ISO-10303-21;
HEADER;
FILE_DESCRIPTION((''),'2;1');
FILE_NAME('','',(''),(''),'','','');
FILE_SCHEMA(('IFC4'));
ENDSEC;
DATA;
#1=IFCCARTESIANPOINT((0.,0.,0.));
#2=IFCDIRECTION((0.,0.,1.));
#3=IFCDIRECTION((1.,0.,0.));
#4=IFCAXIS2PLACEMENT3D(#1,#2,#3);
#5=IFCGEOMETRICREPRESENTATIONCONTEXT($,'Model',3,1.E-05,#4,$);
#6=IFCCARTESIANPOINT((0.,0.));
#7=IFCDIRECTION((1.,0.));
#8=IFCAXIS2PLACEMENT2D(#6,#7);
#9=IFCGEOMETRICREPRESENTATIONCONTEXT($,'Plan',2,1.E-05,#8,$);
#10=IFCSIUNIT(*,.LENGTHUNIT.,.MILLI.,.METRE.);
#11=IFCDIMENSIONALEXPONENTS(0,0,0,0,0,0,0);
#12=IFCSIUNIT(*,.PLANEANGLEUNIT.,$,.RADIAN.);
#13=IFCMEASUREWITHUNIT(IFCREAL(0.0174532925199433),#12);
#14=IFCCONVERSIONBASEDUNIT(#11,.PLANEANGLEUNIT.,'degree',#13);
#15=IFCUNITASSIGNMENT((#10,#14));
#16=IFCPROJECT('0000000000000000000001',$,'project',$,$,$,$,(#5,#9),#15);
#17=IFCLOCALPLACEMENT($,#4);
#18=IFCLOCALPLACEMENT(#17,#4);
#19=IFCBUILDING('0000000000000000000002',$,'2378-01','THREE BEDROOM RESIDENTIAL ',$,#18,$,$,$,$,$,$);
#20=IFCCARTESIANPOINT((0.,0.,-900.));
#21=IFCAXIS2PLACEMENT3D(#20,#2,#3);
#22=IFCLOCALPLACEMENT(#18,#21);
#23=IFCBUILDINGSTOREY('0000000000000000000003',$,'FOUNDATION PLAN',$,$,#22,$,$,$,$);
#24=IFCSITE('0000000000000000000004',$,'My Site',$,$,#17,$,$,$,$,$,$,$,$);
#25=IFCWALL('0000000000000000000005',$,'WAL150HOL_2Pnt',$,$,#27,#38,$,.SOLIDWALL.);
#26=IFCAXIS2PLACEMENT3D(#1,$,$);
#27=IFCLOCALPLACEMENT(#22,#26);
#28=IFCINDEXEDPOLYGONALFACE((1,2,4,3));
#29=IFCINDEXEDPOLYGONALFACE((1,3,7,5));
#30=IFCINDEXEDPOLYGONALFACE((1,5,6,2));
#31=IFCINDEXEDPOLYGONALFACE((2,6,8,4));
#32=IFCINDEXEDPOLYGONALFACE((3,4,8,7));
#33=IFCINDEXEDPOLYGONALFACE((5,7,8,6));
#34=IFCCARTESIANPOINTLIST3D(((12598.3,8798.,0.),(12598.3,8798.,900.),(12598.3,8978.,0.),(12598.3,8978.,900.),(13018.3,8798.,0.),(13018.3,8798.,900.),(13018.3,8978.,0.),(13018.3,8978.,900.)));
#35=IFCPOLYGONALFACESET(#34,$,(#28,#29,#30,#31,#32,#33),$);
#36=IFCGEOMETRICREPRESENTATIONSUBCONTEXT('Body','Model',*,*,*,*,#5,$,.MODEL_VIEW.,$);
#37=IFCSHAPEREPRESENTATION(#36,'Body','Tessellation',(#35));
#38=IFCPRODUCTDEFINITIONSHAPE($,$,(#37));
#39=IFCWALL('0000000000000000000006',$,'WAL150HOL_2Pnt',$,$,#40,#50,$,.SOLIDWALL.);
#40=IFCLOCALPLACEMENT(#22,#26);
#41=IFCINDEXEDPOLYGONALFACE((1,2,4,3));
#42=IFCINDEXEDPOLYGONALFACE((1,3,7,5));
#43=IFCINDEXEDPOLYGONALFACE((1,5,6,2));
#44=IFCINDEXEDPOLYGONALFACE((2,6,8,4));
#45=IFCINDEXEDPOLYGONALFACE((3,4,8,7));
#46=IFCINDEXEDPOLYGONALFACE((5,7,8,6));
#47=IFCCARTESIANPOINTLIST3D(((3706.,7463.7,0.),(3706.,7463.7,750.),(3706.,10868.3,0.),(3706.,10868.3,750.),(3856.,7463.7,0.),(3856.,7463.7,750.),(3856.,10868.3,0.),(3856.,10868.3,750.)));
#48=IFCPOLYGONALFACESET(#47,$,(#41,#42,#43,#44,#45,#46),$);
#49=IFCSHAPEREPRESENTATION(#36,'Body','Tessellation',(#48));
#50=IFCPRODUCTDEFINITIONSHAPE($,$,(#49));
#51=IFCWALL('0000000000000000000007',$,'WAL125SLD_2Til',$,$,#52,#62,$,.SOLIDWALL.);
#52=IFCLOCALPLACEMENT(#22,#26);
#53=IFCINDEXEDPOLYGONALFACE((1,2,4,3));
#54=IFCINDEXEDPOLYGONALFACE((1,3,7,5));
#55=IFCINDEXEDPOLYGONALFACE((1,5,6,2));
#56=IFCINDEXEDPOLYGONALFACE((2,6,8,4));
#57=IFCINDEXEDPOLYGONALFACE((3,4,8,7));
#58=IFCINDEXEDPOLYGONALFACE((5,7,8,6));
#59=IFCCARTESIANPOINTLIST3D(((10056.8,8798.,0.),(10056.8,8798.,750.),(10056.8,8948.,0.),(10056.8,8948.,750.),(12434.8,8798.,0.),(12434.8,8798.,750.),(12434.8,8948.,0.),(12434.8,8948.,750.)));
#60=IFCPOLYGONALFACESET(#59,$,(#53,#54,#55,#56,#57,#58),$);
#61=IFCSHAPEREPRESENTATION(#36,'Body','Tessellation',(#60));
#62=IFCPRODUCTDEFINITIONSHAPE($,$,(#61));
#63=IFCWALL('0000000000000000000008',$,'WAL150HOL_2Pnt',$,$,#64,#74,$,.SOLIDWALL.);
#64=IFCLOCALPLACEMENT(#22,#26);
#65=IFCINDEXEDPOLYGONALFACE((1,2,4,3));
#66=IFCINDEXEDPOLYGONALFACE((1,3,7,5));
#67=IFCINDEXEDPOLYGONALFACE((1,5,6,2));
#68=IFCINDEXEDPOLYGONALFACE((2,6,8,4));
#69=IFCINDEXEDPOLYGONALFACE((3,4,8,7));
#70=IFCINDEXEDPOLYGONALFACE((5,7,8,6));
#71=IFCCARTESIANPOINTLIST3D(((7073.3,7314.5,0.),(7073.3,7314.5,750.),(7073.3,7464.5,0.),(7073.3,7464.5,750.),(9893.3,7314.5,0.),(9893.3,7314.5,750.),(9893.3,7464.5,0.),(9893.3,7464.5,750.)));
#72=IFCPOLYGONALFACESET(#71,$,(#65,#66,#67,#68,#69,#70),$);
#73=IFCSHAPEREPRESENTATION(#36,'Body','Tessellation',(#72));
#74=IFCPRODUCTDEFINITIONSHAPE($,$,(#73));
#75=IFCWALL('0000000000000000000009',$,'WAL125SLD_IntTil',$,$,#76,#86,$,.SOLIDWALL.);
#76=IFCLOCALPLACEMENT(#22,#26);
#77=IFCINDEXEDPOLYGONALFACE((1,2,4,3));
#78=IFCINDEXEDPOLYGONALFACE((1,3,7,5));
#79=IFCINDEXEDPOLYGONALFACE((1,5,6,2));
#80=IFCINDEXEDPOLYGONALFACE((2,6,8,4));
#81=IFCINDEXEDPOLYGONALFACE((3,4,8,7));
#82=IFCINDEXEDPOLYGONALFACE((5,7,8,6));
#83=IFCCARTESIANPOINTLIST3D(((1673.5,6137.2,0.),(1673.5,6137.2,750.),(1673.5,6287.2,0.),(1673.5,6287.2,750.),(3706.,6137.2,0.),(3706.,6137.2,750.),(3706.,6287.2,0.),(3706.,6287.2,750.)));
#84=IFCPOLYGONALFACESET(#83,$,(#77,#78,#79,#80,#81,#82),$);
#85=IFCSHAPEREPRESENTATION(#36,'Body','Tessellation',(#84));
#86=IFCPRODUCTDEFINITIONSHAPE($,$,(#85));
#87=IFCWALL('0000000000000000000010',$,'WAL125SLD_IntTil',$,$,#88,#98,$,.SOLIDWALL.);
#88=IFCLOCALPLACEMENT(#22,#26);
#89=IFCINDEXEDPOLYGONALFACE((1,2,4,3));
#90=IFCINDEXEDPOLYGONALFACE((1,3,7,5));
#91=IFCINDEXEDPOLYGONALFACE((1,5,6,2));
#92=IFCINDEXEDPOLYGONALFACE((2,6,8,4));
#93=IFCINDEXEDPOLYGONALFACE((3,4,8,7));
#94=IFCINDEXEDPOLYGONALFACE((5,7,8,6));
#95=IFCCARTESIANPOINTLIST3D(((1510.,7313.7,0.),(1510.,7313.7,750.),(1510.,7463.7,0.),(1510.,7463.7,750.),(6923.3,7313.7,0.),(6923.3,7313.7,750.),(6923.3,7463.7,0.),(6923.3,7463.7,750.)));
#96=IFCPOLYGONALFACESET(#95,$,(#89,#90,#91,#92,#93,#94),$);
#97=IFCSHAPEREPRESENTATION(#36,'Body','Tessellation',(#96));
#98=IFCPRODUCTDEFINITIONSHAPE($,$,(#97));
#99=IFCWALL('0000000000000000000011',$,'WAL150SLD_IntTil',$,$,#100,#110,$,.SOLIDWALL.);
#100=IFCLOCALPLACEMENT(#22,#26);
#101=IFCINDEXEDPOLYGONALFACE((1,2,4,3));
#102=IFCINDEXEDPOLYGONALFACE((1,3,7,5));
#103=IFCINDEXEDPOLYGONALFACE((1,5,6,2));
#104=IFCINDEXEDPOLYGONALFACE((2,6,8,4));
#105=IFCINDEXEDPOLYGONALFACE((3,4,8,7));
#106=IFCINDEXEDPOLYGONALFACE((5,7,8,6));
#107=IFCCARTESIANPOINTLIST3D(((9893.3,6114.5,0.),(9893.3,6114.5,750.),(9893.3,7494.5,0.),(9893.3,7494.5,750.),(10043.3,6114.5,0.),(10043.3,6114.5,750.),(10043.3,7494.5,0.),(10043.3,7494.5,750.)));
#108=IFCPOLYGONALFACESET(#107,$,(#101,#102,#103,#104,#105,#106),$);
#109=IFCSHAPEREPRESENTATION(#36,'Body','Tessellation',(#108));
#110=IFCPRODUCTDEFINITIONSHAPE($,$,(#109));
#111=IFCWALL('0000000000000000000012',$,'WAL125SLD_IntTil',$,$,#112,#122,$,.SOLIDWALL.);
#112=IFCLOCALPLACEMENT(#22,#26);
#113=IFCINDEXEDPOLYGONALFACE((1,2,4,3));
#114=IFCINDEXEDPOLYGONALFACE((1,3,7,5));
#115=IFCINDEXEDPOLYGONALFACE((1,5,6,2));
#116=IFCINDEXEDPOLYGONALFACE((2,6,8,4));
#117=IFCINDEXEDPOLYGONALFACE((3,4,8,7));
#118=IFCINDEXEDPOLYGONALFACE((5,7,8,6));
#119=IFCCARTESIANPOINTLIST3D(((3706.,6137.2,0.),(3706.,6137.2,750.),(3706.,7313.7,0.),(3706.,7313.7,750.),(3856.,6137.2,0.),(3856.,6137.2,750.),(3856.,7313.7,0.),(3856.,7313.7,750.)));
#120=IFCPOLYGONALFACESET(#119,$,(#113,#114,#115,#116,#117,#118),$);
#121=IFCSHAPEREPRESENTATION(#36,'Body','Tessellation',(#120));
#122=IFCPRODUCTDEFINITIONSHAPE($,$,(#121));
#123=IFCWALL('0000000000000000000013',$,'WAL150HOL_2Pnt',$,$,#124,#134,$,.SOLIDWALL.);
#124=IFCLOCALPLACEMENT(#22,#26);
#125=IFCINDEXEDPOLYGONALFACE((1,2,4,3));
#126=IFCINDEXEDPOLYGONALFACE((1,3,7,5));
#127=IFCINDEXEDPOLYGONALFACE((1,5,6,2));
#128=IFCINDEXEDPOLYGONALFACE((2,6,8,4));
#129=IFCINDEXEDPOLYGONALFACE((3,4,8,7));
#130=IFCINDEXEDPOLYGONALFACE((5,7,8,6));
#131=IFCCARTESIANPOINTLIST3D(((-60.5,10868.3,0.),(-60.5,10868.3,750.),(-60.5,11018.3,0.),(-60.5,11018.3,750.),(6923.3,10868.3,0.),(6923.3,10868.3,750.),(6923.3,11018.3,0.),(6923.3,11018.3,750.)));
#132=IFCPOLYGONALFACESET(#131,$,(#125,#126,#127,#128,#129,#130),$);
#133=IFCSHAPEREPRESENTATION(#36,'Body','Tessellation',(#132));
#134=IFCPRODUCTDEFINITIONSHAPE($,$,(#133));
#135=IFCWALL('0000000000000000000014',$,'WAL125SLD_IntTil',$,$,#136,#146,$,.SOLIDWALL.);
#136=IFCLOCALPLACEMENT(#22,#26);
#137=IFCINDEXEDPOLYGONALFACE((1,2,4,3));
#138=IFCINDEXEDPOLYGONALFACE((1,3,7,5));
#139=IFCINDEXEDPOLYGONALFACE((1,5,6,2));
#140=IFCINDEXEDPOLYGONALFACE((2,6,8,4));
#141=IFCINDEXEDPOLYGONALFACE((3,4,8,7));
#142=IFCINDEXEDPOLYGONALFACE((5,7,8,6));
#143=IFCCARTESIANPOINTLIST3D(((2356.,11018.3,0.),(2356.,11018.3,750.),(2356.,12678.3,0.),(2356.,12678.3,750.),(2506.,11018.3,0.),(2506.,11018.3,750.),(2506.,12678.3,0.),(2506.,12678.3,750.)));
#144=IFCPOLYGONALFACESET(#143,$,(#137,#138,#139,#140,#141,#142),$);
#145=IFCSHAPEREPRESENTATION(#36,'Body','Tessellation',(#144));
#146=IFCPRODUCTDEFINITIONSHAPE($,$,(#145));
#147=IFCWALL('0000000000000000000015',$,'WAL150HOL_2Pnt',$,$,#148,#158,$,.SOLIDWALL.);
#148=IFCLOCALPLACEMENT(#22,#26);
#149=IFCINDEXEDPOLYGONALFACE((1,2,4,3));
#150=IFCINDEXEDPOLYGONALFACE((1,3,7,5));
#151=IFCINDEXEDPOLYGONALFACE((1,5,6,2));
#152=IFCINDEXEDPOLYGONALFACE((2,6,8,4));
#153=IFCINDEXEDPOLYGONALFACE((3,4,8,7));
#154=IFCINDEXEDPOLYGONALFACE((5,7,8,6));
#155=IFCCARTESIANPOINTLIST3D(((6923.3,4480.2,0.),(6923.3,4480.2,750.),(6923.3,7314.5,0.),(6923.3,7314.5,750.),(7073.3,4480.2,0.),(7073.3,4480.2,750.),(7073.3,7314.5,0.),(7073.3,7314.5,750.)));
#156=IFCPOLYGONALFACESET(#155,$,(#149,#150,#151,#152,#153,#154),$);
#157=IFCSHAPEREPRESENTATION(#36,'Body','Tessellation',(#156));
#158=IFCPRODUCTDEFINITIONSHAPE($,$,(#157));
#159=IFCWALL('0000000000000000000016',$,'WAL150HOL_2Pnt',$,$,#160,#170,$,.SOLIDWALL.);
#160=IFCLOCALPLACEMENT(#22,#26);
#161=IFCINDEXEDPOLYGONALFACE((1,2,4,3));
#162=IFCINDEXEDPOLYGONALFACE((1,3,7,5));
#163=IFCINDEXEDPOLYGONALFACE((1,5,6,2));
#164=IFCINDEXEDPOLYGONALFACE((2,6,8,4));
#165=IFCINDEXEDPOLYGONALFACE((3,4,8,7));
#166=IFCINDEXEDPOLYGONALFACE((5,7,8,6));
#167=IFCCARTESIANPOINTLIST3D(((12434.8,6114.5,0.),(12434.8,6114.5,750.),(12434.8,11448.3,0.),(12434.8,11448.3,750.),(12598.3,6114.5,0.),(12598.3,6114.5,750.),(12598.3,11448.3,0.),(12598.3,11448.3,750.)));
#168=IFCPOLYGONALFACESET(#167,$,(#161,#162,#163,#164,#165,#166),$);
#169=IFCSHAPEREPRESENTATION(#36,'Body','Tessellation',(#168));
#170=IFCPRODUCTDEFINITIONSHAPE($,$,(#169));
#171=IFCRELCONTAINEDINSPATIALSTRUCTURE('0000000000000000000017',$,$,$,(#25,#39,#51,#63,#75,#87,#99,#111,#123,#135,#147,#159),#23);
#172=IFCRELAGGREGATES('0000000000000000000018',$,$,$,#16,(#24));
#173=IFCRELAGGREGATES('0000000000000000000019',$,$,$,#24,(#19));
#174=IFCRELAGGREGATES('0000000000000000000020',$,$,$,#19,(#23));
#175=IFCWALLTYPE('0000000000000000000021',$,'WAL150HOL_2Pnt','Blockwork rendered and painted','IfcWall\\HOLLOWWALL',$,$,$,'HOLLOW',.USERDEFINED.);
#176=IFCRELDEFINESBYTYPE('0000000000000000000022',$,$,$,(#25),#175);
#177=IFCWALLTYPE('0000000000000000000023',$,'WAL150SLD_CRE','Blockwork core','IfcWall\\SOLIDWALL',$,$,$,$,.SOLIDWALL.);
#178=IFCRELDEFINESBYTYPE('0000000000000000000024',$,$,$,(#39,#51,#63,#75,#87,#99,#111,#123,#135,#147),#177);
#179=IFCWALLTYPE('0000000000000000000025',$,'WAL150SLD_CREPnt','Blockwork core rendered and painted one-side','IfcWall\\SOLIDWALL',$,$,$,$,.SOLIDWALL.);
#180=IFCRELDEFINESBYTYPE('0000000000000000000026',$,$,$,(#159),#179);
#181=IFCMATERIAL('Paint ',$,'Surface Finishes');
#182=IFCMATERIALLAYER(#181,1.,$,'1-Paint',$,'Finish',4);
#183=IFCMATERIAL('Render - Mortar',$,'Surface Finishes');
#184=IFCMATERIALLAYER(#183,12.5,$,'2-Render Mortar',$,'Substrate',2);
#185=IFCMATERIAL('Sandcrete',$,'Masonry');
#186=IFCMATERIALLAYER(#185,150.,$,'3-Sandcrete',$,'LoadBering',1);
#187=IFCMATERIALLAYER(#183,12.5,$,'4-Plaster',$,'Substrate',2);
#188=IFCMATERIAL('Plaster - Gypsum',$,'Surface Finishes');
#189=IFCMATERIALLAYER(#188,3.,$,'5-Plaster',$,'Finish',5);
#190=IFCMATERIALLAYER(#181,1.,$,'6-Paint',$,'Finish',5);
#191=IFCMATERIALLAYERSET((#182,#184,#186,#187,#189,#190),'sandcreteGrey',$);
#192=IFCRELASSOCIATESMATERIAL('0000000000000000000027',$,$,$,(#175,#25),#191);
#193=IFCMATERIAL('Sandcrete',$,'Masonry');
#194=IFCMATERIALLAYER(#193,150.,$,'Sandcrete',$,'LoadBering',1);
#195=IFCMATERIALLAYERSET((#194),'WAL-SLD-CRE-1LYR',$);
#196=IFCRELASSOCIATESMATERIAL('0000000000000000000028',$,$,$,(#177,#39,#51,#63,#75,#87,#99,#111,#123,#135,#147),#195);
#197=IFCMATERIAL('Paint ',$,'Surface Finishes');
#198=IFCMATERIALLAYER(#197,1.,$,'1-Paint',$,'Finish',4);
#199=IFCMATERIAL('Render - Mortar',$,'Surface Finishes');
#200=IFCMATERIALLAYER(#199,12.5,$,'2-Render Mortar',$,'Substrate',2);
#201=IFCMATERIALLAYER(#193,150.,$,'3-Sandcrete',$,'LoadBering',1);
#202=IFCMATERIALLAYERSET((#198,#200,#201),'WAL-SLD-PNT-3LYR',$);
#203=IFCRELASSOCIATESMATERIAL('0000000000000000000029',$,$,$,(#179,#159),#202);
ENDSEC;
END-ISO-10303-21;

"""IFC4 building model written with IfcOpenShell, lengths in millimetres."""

from ifc_helpers import new_model, entity, si_unit, converted_unit, frame, origin_with_axes, origin_2d_with_axis, place, context, subcontext, project, spatial, indexed_curve, outline, extrude, material, layer, layer_set, layer_usage, type_object, element, save


model = new_model("IFC4")

# Units and contexts
model_context = context("Model", 3, precision=1e-05, world=origin_with_axes())
plan_context = context("Plan", 2, precision=1e-05, world=origin_2d_with_axis())
body_context = subcontext(model_context, "Body", "Model", "MODEL_VIEW")
ifc_project = project(units=[si_unit("LENGTHUNIT", "METRE", prefix="MILLI"), converted_unit("PLANEANGLEUNIT", "degree", entity("IfcReal", 0.0174532925199433), si_unit("PLANEANGLEUNIT", "RADIAN"), dimensions=[0, 0, 0, 0, 0, 0, 0])], contexts=[model_context, plan_context])

# Site, building, storey
site_placement = place(None, origin_with_axes())
site = spatial("IfcSite", under=ifc_project, at=site_placement, Name="My Site")
building_placement = place(site_placement, origin_with_axes())
building = spatial("IfcBuilding", under=site, at=building_placement, Name="2378-01", Description="THREE BEDROOM RESIDENTIAL ")
storey_placement = place(building_placement, frame((0.0, 0.0, -900.0), z_axis=(0.0, 0.0, 1.0), x_axis=(1.0, 0.0, 0.0)))
storey = spatial("IfcBuildingStorey", under=building, at=storey_placement, Name="FOUNDATION PLAN")

# Walls
ifc_material_1 = material(Name="Paint ", Category="Surface Finishes")
ifc_layer_1 = layer(ifc_material_1, 1.0, Name="1-Paint", Category="Finish", Priority=4)
ifc_material_2 = material(Name="Render - Mortar", Category="Surface Finishes")
ifc_layer_2 = layer(ifc_material_2, 12.5, Name="2-Render Mortar", Category="Substrate", Priority=2)
ifc_material_3 = material(Name="Sandcrete", Category="Masonry")
ifc_layer_3 = layer(ifc_material_3, 150.0, Name="3-Sandcrete", Category="LoadBering", Priority=1)
ifc_layer_4 = layer(ifc_material_2, 12.5, Name="4-Plaster", Category="Substrate", Priority=2)
ifc_material_4 = material(Name="Plaster - Gypsum", Category="Surface Finishes")
ifc_layer_5 = layer(ifc_material_4, 3.0, Name="5-Plaster", Category="Finish", Priority=5)
ifc_layer_6 = layer(ifc_material_1, 1.0, Name="6-Paint", Category="Finish", Priority=5)
ifc_layer_set_1 = layer_set([ifc_layer_1, ifc_layer_2, ifc_layer_3, ifc_layer_4, ifc_layer_5, ifc_layer_6], Name="sandcreteGrey")
ifc_layer_usage_1 = layer_usage(ifc_layer_set_1, "AXIS2", "POSITIVE", 0.0)
wall_type_1 = type_object("IfcWallType", Name="WAL150HOL_2Pnt", Description="Blockwork rendered and painted", ApplicableOccurrence="IfcWall\\HOLLOWWALL", ElementType="HOLLOW", PredefinedType="USERDEFINED", material=ifc_layer_set_1)
wall_1_placement = place(storey_placement, frame((13018.3, 8978.0, 0.0), z_axis=(0.0, 0.0, 1.0), x_axis=(-1.0, 0.000001, 0.0)))
element("IfcWall", 1, at=wall_1_placement, inside=storey, type_object=wall_type_1, material=ifc_layer_usage_1, Name="WAL150HOL_2Pnt", PredefinedType="SOLIDWALL", context=body_context, shape_type="SweptSolid", body=[
    extrude(outline(indexed_curve([(0.0, 0.0), (0.0, 180.0), (420.0, 180.0), (420.0, 0.0), (0.0, 0.0)], self_intersect=False)), origin_with_axes(), (0.0, 0.0, 1.0), 900.0),
])
ifc_material_5 = material(Name="Sandcrete", Category="Masonry")
ifc_layer_7 = layer(ifc_material_5, 150.0, Name="Sandcrete", Category="LoadBering", Priority=1)
ifc_layer_set_2 = layer_set([ifc_layer_7], Name="WAL-SLD-CRE-1LYR")
ifc_layer_usage_2 = layer_usage(ifc_layer_set_2, "AXIS2", "POSITIVE", 0.0)
wall_type_2 = type_object("IfcWallType", Name="WAL150SLD_CRE", Description="Blockwork core", ApplicableOccurrence="IfcWall\\SOLIDWALL", PredefinedType="SOLIDWALL", material=ifc_layer_set_2)
wall_2_placement = place(storey_placement, frame((3856.0, 7463.7, 0.0), z_axis=(0.0, 0.0, 1.0), x_axis=(0.0, 1.0, 0.0)))
element("IfcWall", 2, at=wall_2_placement, inside=storey, type_object=wall_type_2, material=ifc_layer_usage_2, Name="WAL150HOL_2Pnt", PredefinedType="SOLIDWALL", context=body_context, shape_type="SweptSolid", body=[
    extrude(outline(indexed_curve([(0.0, 0.0), (0.0, 150.0), (3404.6, 150.0), (3404.6, 0.0), (0.0, 0.0)], self_intersect=False)), origin_with_axes(), (0.0, 0.0, 1.0), 750.0),
])
ifc_layer_usage_3 = layer_usage(ifc_layer_set_2, "AXIS2", "POSITIVE", 0.0)
wall_3_placement = place(storey_placement, frame((10056.8, 8798.0, 0.0), z_axis=(0.0, 0.0, 1.0), x_axis=(1.0, -0.000001, 0.0)))
element("IfcWall", 3, at=wall_3_placement, inside=storey, type_object=wall_type_2, material=ifc_layer_usage_3, Name="WAL125SLD_2Til", PredefinedType="SOLIDWALL", context=body_context, shape_type="SweptSolid", body=[
    extrude(outline(indexed_curve([(0.0, 0.0), (0.0, 150.0), (2378.0, 150.0), (2378.0, 0.0), (0.0, 0.0)], self_intersect=False)), origin_with_axes(), (0.0, 0.0, 1.0), 750.0),
])
ifc_layer_usage_4 = layer_usage(ifc_layer_set_2, "AXIS2", "POSITIVE", 0.0)
wall_4_placement = place(storey_placement, frame((7073.3, 7314.5, 0.0), z_axis=(0.0, 0.0, 1.0), x_axis=(1.0, 0.0, 0.0)))
element("IfcWall", 4, at=wall_4_placement, inside=storey, type_object=wall_type_2, material=ifc_layer_usage_4, Name="WAL150HOL_2Pnt", PredefinedType="SOLIDWALL", context=body_context, shape_type="SweptSolid", body=[
    extrude(outline(indexed_curve([(0.0, 0.0), (0.0, 150.0), (2820.0, 150.0), (2820.0, 0.0), (0.0, 0.0)], self_intersect=False)), origin_with_axes(), (0.0, 0.0, 1.0), 750.0),
])
ifc_layer_usage_5 = layer_usage(ifc_layer_set_2, "AXIS2", "POSITIVE", 0.0)
wall_5_placement = place(storey_placement, frame((1673.5, 6137.2, 0.0), z_axis=(0.0, 0.0, 1.0), x_axis=(1.0, 0.0, 0.0)))
element("IfcWall", 5, at=wall_5_placement, inside=storey, type_object=wall_type_2, material=ifc_layer_usage_5, Name="WAL125SLD_IntTil", PredefinedType="SOLIDWALL", context=body_context, shape_type="SweptSolid", body=[
    extrude(outline(indexed_curve([(0.0, 0.0), (0.0, 150.0), (2032.5, 150.0), (2032.5, 0.0), (0.0, 0.0)], self_intersect=False)), origin_with_axes(), (0.0, 0.0, 1.0), 750.0),
])
ifc_layer_usage_6 = layer_usage(ifc_layer_set_2, "AXIS2", "POSITIVE", 0.0)
wall_6_placement = place(storey_placement, frame((6923.3, 7463.7, 0.0), z_axis=(0.0, 0.0, 1.0), x_axis=(-1.0, 0.0, 0.0)))
element("IfcWall", 6, at=wall_6_placement, inside=storey, type_object=wall_type_2, material=ifc_layer_usage_6, Name="WAL125SLD_IntTil", PredefinedType="SOLIDWALL", context=body_context, shape_type="SweptSolid", body=[
    extrude(outline(indexed_curve([(0.0, 0.0), (0.0, 150.0), (5413.3, 150.0), (5413.3, 0.0), (0.0, 0.0)], self_intersect=False)), origin_with_axes(), (0.0, 0.0, 1.0), 750.0),
])
ifc_layer_usage_7 = layer_usage(ifc_layer_set_2, "AXIS2", "POSITIVE", 0.0)
wall_7_placement = place(storey_placement, frame((9893.3, 7494.5, 0.0), z_axis=(0.0, 0.0, 1.0), x_axis=(-0.000001, -1.0, 0.0)))
element("IfcWall", 7, at=wall_7_placement, inside=storey, type_object=wall_type_2, material=ifc_layer_usage_7, Name="WAL150SLD_IntTil", PredefinedType="SOLIDWALL", context=body_context, shape_type="SweptSolid", body=[
    extrude(outline(indexed_curve([(0.0, 0.0), (0.0, 150.0), (1380.0, 150.0), (1380.0, 0.0), (0.0, 0.0)], self_intersect=False)), origin_with_axes(), (0.0, 0.0, 1.0), 750.0),
])
ifc_layer_usage_8 = layer_usage(ifc_layer_set_2, "AXIS2", "POSITIVE", 0.0)
wall_8_placement = place(storey_placement, frame((3856.0, 6137.2, 0.0), z_axis=(0.0, 0.0, 1.0), x_axis=(0.0, 1.0, 0.0)))
element("IfcWall", 8, at=wall_8_placement, inside=storey, type_object=wall_type_2, material=ifc_layer_usage_8, Name="WAL125SLD_IntTil", PredefinedType="SOLIDWALL", context=body_context, shape_type="SweptSolid", body=[
    extrude(outline(indexed_curve([(0.0, 0.0), (0.0, 150.0), (1176.5, 150.0), (1176.5, 0.0), (0.0, 0.0)], self_intersect=False)), origin_with_axes(), (0.0, 0.0, 1.0), 750.0),
])
ifc_layer_usage_9 = layer_usage(ifc_layer_set_2, "AXIS2", "POSITIVE", 0.0)
wall_9_placement = place(storey_placement, frame((-60.5, 10868.3, 0.0), z_axis=(0.0, 0.0, 1.0), x_axis=(1.0, -0.000002, 0.0)))
element("IfcWall", 9, at=wall_9_placement, inside=storey, type_object=wall_type_2, material=ifc_layer_usage_9, Name="WAL150HOL_2Pnt", PredefinedType="SOLIDWALL", context=body_context, shape_type="SweptSolid", body=[
    extrude(outline(indexed_curve([(0.0, 0.0), (0.0, 150.0), (6983.8, 150.0), (6983.8, 0.0), (0.0, 0.0)], self_intersect=False)), origin_with_axes(), (0.0, 0.0, 1.0), 750.0),
])
ifc_layer_usage_10 = layer_usage(ifc_layer_set_2, "AXIS2", "POSITIVE", 0.0)
wall_10_placement = place(storey_placement, frame((2506.0, 11018.3, 0.0), z_axis=(0.0, 0.0, 1.0), x_axis=(0.0, 1.0, 0.0)))
element("IfcWall", 10, at=wall_10_placement, inside=storey, type_object=wall_type_2, material=ifc_layer_usage_10, Name="WAL125SLD_IntTil", PredefinedType="SOLIDWALL", context=body_context, shape_type="SweptSolid", body=[
    extrude(outline(indexed_curve([(0.0, 0.0), (0.0, 150.0), (1660.0, 150.0), (1660.0, 0.0), (0.0, 0.0)], self_intersect=False)), origin_with_axes(), (0.0, 0.0, 1.0), 750.0),
])
ifc_layer_usage_11 = layer_usage(ifc_layer_set_2, "AXIS2", "POSITIVE", 0.0)
wall_11_placement = place(storey_placement, frame((7073.3, 4480.2, 0.0), z_axis=(0.0, 0.0, 1.0), x_axis=(0.000002, 1.0, 0.0)))
element("IfcWall", 11, at=wall_11_placement, inside=storey, type_object=wall_type_2, material=ifc_layer_usage_11, Name="WAL150HOL_2Pnt", PredefinedType="SOLIDWALL", context=body_context, shape_type="SweptSolid", body=[
    extrude(outline(indexed_curve([(0.0, 0.0), (0.0, 150.0), (2834.3, 150.0), (2834.3, 0.0), (0.0, 0.0)], self_intersect=False)), origin_with_axes(), (0.0, 0.0, 1.0), 750.0),
])
ifc_material_6 = material(Name="Paint ", Category="Surface Finishes")
ifc_layer_8 = layer(ifc_material_6, 1.0, Name="1-Paint", Category="Finish", Priority=4)
ifc_material_7 = material(Name="Render - Mortar", Category="Surface Finishes")
ifc_layer_9 = layer(ifc_material_7, 12.5, Name="2-Render Mortar", Category="Substrate", Priority=2)
ifc_layer_10 = layer(ifc_material_5, 150.0, Name="3-Sandcrete", Category="LoadBering", Priority=1)
ifc_layer_set_3 = layer_set([ifc_layer_8, ifc_layer_9, ifc_layer_10], Name="WAL-SLD-PNT-3LYR")
ifc_layer_usage_12 = layer_usage(ifc_layer_set_3, "AXIS2", "POSITIVE", 0.0)
wall_type_3 = type_object("IfcWallType", Name="WAL150SLD_CREPnt", Description="Blockwork core rendered and painted one-side", ApplicableOccurrence="IfcWall\\SOLIDWALL", PredefinedType="SOLIDWALL", material=ifc_layer_set_3)
wall_12_placement = place(storey_placement, frame((12598.3, 6114.5, 0.0), z_axis=(0.0, 0.0, 1.0), x_axis=(0.000002, 1.0, 0.0)))
element("IfcWall", 12, at=wall_12_placement, inside=storey, type_object=wall_type_3, material=ifc_layer_usage_12, Name="WAL150HOL_2Pnt", PredefinedType="SOLIDWALL", context=body_context, shape_type="SweptSolid", body=[
    extrude(outline(indexed_curve([(0.0, 0.0), (0.0, 163.5), (5333.8, 163.5), (5333.8, 0.0), (0.0, 0.0)], self_intersect=False)), origin_with_axes(), (0.0, 0.0, 1.0), 750.0),
])

save(model, "model.ifc")
